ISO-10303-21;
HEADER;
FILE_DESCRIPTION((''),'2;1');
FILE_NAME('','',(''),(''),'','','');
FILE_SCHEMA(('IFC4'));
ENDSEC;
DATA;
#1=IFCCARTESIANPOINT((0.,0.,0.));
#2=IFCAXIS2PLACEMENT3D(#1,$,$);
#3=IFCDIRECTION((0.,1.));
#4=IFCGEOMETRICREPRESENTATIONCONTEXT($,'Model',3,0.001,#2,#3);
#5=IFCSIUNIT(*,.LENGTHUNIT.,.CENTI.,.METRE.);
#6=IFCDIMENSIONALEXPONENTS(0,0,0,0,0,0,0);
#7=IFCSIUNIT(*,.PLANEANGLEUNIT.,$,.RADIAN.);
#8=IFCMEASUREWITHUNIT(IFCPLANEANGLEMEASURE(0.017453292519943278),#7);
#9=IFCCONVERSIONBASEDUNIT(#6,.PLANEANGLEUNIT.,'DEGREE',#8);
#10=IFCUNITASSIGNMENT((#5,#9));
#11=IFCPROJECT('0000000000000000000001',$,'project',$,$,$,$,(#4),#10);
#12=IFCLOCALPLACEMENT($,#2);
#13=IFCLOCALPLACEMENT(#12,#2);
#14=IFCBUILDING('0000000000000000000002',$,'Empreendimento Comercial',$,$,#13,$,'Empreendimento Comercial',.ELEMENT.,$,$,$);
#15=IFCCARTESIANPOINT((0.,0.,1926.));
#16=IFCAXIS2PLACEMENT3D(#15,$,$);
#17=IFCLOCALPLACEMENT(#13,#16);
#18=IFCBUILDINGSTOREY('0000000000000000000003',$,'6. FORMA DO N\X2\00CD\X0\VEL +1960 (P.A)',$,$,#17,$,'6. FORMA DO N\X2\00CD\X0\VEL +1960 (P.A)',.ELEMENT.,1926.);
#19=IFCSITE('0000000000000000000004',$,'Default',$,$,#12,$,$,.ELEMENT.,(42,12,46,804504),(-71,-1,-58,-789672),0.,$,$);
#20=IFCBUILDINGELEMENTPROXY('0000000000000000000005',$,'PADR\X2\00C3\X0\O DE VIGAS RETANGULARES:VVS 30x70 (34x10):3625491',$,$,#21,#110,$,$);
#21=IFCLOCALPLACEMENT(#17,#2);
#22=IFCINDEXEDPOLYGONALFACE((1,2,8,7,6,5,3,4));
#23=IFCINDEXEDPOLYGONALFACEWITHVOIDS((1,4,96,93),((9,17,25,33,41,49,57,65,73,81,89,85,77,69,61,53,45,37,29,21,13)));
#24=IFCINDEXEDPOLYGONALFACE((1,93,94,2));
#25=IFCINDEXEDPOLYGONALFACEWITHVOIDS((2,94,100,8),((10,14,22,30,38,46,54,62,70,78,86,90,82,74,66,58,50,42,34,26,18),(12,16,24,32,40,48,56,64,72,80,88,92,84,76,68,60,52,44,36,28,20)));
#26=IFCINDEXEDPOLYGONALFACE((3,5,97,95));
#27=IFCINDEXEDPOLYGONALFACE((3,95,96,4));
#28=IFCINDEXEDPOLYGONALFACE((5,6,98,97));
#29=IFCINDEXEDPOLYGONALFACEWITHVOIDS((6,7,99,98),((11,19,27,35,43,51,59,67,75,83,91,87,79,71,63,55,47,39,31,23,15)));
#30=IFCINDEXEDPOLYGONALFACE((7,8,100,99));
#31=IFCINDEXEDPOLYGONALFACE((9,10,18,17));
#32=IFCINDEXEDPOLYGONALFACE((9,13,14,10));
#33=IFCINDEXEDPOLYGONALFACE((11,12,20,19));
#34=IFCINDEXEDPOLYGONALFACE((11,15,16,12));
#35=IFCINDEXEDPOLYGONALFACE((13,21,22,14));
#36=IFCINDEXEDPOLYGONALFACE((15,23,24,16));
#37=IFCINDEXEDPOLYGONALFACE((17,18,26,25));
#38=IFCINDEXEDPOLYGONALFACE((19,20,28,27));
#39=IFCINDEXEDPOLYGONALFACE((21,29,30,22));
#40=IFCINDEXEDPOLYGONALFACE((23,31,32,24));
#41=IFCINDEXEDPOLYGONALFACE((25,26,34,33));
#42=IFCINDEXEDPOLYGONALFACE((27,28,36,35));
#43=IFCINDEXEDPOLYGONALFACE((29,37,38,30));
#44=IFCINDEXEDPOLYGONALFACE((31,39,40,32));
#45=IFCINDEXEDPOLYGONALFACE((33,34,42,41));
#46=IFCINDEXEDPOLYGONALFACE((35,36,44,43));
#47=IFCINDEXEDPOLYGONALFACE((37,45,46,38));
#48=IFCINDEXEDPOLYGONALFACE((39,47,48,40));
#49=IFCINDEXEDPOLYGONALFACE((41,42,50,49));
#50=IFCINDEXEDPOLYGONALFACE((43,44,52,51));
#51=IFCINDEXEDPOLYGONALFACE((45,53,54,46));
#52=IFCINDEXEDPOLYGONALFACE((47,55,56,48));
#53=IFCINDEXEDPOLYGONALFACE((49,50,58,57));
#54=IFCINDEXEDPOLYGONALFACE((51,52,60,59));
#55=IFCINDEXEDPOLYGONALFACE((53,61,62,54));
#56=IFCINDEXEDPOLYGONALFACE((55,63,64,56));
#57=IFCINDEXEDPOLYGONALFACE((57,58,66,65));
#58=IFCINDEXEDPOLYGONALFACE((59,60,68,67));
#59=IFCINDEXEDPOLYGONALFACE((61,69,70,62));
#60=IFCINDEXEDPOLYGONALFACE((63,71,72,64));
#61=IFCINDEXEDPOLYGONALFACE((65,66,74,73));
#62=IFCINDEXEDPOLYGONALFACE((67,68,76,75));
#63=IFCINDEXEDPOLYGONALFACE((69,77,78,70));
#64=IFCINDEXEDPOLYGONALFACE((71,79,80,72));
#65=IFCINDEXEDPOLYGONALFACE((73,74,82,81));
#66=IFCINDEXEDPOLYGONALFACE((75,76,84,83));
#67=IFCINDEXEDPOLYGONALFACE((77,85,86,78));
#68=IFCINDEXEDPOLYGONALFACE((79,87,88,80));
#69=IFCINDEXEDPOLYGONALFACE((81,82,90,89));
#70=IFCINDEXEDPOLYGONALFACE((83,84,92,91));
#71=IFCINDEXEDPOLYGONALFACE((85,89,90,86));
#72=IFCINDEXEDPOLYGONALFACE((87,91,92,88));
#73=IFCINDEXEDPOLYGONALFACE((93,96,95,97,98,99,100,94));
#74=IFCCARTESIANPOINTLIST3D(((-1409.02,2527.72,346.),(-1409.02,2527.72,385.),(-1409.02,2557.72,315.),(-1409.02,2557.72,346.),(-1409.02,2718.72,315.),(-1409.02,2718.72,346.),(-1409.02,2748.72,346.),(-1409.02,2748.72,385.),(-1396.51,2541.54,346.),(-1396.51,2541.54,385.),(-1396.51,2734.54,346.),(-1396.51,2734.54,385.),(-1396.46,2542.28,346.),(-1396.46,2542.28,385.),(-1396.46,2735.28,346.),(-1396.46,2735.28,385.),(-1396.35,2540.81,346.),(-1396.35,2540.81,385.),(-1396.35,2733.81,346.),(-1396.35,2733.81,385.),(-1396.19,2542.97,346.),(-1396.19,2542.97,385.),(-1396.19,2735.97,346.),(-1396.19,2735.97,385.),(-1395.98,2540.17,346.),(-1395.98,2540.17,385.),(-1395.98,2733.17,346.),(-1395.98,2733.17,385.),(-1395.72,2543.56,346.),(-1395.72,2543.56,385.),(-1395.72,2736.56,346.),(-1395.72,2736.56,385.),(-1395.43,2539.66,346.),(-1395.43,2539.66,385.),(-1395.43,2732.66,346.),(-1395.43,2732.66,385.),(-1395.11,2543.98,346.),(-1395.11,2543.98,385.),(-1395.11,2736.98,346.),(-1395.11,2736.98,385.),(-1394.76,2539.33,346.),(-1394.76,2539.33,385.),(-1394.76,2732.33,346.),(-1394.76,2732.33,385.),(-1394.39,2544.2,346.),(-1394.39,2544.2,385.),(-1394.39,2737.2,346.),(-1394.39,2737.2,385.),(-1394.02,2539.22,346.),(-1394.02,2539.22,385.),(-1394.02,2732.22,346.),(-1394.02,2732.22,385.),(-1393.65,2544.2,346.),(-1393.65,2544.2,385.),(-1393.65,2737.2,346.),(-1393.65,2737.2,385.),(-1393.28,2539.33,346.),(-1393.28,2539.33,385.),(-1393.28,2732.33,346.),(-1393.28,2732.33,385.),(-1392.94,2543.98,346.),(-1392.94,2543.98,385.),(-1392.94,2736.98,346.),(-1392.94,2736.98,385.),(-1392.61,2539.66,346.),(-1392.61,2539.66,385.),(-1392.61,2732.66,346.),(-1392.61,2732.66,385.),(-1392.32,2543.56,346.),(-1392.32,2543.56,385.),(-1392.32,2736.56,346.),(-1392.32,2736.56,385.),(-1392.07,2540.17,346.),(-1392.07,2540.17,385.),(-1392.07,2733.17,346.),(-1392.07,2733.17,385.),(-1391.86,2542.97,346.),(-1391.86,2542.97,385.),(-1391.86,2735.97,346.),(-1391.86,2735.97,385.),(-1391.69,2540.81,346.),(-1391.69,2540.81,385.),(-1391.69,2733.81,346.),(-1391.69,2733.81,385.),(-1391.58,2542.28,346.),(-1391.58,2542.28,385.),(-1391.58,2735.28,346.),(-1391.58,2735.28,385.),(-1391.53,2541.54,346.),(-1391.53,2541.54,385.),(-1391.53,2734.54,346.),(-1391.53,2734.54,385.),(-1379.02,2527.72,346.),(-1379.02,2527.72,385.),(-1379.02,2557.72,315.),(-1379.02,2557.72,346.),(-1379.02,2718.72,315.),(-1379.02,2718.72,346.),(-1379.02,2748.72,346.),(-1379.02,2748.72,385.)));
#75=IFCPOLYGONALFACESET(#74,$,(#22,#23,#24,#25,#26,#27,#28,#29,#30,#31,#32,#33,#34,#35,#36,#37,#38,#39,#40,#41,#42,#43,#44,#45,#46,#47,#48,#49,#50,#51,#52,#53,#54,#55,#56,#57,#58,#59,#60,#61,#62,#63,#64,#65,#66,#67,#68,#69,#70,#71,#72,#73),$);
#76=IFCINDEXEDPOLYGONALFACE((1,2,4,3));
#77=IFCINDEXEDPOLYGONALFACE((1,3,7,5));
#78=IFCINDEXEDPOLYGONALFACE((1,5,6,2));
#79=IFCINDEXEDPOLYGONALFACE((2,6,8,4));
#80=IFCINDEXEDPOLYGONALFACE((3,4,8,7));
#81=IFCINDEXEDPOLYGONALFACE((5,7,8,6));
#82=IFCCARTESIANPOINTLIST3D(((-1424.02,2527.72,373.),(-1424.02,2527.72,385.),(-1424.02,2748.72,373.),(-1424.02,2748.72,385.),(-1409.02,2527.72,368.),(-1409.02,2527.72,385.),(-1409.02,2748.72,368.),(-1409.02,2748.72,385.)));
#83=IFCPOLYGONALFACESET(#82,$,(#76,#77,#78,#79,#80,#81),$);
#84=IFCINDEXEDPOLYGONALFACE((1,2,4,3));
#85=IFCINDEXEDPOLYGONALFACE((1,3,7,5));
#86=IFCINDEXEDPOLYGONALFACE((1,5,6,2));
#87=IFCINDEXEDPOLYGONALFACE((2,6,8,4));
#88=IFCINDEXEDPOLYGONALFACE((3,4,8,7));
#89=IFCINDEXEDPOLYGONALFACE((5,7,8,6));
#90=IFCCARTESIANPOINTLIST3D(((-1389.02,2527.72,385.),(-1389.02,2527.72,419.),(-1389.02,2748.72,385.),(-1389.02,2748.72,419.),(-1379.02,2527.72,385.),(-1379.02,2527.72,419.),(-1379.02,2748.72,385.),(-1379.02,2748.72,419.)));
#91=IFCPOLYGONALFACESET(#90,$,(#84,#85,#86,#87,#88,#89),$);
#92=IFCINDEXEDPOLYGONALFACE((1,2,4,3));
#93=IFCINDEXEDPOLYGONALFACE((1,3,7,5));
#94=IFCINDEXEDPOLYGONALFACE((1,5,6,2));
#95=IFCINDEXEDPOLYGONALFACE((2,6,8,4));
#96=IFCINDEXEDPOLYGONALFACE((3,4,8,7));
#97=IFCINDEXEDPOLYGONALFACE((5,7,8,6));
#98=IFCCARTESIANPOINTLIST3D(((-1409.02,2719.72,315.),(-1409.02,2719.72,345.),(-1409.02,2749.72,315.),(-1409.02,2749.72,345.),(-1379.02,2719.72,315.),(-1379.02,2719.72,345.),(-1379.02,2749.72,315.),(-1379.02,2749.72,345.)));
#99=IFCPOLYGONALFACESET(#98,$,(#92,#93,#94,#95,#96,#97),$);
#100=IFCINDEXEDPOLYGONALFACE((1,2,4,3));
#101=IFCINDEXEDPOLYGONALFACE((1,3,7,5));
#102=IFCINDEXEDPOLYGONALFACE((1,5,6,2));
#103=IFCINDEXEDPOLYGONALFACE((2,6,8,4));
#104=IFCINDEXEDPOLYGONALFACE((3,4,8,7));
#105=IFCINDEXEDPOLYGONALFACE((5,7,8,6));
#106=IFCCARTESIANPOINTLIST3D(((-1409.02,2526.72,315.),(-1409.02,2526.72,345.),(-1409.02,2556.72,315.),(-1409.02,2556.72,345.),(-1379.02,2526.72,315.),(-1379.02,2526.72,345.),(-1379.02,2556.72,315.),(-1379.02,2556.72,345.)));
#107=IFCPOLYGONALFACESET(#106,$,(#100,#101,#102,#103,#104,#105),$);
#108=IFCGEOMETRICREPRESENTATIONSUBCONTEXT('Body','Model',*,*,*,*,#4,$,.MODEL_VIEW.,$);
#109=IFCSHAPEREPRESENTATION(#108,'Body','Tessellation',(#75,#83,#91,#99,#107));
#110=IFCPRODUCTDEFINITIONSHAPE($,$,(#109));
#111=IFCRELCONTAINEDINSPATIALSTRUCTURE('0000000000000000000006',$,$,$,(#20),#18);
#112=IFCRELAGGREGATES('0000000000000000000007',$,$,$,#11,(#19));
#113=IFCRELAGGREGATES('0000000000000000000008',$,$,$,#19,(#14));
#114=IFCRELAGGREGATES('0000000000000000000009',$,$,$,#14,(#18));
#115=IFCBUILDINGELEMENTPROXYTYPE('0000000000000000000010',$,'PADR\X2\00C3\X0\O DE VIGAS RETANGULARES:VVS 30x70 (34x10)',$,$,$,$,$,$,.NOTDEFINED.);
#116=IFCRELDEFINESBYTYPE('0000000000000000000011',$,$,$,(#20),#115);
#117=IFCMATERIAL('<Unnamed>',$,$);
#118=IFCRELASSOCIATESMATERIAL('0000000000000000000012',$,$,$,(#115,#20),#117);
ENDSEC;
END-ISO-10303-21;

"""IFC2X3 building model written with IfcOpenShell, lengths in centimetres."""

from ifc_helpers import new_model, entity, si_unit, converted_unit, direction, frame, frame_2d, origin, origin_2d_with_axis, place, context, subcontext, project, spatial, polyline, rectangle, circle, outline, extrude, source, transform, mapped, material, type_object, type_shapes, element, save


model = new_model("IFC2X3")

# Units and contexts
model_context = context("Model", 3, precision=0.001, world=origin(), true_north=direction((0.0, 1.0)))
body_context = subcontext(model_context, "Body", "Model", "MODEL_VIEW")
ifc_project = project(units=[si_unit("LENGTHUNIT", "METRE", prefix="CENTI"), converted_unit("PLANEANGLEUNIT", "DEGREE", entity("IfcPlaneAngleMeasure", 0.017453292519943278), si_unit("PLANEANGLEUNIT", "RADIAN"), dimensions=[0, 0, 0, 0, 0, 0, 0])], contexts=[model_context])

# Site, building, storey
site_placement = place(None, origin())
site = spatial("IfcSite", under=ifc_project, at=site_placement, Name="Default", CompositionType="ELEMENT", RefLatitude=(42, 12, 46, 804504), RefLongitude=(-71, -1, -58, -789672), RefElevation=0.0)
building_placement = place(site_placement, origin())
building = spatial("IfcBuilding", under=site, at=building_placement, Name="Empreendimento Comercial", LongName="Empreendimento Comercial", CompositionType="ELEMENT")
storey_placement = place(building_placement, frame((0.0, 0.0, 1926.0)))
storey = spatial("IfcBuildingStorey", under=building, at=storey_placement, Name="6. FORMA DO NÍVEL +1960 (P.A)", LongName="6. FORMA DO NÍVEL +1960 (P.A)", CompositionType="ELEMENT", Elevation=1926.0)

# Building element proxy, openings
ifc_material_1 = material(Name="<Unnamed>")
building_element_proxy_type_1 = type_object("IfcBuildingElementProxyType", Name="PADRÃO DE VIGAS RETANGULARES:VVS 30x70 (34x10)", PredefinedType="NOTDEFINED", material=ifc_material_1)
shared_shape_1 = source(origin(), body_context, "Body", "SweptSolid", [
    extrude(outline(polyline([(-37.0, -110.5), (2.0, -110.5), (2.0, -80.5), (33.0, -80.5), (33.0, 80.5), (2.0, 80.5), (2.0, 110.5), (-37.0, 110.5), (-37.0, -110.5)])), frame((-1409.02, 2638.22, 2274.0), z_axis=(1.0, 0.0, 0.0), x_axis=(0.0, 0.0, -1.0)), (0.0, 0.0, 1.0), 30.0),
    extrude(outline(polyline([(-7.5, -7.25), (7.5, -7.25), (7.5, 9.75), (-7.5, 4.75), (-7.5, -7.25)])), frame((-1416.52, 2527.72, 2303.75), z_axis=(0.0, 1.0, 0.0), x_axis=(1.0, 0.0, 0.0)), (0.0, 0.0, 1.0), 221.0),
    extrude(rectangle(XDim=221.0, YDim=10.0, at=frame_2d((0.0, 0.0), x_axis=(1.0, 0.0))), frame((-1384.02, 2638.22, 2311.0), z_axis=(0.0, 0.0, 1.0), x_axis=(0.0, 1.0, 0.0)), (0.0, 0.0, 1.0), 34.0),
    extrude(rectangle(XDim=30.0, YDim=30.0, at=frame_2d((0.0, 0.0), x_axis=(1.0, 0.0))), frame((-1394.02, 2734.72, 2241.0)), (0.0, 0.0, 1.0), 30.0),
    extrude(rectangle(XDim=30.0, YDim=30.0, at=origin_2d_with_axis()), frame((-1394.02, 2541.72, 2241.0)), (0.0, 0.0, 1.0), 30.0),
])
type_shapes(building_element_proxy_type_1, [shared_shape_1])
proxy_1_placement = place(storey_placement, frame((0.0, 0.0, -1926.0)))
proxy_1 = element("IfcBuildingElementProxy", 1, at=proxy_1_placement, inside=storey, type_object=building_element_proxy_type_1, material=ifc_material_1, Name="PADRÃO DE VIGAS RETANGULARES:VVS 30x70 (34x10):3625491", context=body_context, shape_type="MappedRepresentation", body=[
    mapped(shared_shape_1, transform((0.0, 0.0, 0.0), scale=1.0)),
])
opening_1_placement = place(storey_placement, frame((0.0, 0.0, -1926.0)))
element("IfcOpeningElement", 2, at=opening_1_placement, cuts=proxy_1, ObjectType="Opening", context=body_context, shape_type="SweptSolid", body=[
    extrude(circle(Radius=2.5, at=origin_2d_with_axis()), frame((-1394.02, 2541.72, 2311.0), z_axis=(0.0, 0.0, -1.0), x_axis=(0.0, -1.0, 0.0)), (0.0, 0.0, 1.0), 39.0),
])
opening_2_placement = place(storey_placement, frame((0.0, 0.0, -1926.0)))
element("IfcOpeningElement", 3, at=opening_2_placement, cuts=proxy_1, ObjectType="Opening", context=body_context, shape_type="SweptSolid", body=[
    extrude(circle(Radius=2.5, at=origin_2d_with_axis()), frame((-1394.02, 2734.72, 2311.0), z_axis=(0.0, 0.0, -1.0), x_axis=(0.0, -1.0, 0.0)), (0.0, 0.0, 1.0), 39.0),
])

save(model, "model.ifc")
